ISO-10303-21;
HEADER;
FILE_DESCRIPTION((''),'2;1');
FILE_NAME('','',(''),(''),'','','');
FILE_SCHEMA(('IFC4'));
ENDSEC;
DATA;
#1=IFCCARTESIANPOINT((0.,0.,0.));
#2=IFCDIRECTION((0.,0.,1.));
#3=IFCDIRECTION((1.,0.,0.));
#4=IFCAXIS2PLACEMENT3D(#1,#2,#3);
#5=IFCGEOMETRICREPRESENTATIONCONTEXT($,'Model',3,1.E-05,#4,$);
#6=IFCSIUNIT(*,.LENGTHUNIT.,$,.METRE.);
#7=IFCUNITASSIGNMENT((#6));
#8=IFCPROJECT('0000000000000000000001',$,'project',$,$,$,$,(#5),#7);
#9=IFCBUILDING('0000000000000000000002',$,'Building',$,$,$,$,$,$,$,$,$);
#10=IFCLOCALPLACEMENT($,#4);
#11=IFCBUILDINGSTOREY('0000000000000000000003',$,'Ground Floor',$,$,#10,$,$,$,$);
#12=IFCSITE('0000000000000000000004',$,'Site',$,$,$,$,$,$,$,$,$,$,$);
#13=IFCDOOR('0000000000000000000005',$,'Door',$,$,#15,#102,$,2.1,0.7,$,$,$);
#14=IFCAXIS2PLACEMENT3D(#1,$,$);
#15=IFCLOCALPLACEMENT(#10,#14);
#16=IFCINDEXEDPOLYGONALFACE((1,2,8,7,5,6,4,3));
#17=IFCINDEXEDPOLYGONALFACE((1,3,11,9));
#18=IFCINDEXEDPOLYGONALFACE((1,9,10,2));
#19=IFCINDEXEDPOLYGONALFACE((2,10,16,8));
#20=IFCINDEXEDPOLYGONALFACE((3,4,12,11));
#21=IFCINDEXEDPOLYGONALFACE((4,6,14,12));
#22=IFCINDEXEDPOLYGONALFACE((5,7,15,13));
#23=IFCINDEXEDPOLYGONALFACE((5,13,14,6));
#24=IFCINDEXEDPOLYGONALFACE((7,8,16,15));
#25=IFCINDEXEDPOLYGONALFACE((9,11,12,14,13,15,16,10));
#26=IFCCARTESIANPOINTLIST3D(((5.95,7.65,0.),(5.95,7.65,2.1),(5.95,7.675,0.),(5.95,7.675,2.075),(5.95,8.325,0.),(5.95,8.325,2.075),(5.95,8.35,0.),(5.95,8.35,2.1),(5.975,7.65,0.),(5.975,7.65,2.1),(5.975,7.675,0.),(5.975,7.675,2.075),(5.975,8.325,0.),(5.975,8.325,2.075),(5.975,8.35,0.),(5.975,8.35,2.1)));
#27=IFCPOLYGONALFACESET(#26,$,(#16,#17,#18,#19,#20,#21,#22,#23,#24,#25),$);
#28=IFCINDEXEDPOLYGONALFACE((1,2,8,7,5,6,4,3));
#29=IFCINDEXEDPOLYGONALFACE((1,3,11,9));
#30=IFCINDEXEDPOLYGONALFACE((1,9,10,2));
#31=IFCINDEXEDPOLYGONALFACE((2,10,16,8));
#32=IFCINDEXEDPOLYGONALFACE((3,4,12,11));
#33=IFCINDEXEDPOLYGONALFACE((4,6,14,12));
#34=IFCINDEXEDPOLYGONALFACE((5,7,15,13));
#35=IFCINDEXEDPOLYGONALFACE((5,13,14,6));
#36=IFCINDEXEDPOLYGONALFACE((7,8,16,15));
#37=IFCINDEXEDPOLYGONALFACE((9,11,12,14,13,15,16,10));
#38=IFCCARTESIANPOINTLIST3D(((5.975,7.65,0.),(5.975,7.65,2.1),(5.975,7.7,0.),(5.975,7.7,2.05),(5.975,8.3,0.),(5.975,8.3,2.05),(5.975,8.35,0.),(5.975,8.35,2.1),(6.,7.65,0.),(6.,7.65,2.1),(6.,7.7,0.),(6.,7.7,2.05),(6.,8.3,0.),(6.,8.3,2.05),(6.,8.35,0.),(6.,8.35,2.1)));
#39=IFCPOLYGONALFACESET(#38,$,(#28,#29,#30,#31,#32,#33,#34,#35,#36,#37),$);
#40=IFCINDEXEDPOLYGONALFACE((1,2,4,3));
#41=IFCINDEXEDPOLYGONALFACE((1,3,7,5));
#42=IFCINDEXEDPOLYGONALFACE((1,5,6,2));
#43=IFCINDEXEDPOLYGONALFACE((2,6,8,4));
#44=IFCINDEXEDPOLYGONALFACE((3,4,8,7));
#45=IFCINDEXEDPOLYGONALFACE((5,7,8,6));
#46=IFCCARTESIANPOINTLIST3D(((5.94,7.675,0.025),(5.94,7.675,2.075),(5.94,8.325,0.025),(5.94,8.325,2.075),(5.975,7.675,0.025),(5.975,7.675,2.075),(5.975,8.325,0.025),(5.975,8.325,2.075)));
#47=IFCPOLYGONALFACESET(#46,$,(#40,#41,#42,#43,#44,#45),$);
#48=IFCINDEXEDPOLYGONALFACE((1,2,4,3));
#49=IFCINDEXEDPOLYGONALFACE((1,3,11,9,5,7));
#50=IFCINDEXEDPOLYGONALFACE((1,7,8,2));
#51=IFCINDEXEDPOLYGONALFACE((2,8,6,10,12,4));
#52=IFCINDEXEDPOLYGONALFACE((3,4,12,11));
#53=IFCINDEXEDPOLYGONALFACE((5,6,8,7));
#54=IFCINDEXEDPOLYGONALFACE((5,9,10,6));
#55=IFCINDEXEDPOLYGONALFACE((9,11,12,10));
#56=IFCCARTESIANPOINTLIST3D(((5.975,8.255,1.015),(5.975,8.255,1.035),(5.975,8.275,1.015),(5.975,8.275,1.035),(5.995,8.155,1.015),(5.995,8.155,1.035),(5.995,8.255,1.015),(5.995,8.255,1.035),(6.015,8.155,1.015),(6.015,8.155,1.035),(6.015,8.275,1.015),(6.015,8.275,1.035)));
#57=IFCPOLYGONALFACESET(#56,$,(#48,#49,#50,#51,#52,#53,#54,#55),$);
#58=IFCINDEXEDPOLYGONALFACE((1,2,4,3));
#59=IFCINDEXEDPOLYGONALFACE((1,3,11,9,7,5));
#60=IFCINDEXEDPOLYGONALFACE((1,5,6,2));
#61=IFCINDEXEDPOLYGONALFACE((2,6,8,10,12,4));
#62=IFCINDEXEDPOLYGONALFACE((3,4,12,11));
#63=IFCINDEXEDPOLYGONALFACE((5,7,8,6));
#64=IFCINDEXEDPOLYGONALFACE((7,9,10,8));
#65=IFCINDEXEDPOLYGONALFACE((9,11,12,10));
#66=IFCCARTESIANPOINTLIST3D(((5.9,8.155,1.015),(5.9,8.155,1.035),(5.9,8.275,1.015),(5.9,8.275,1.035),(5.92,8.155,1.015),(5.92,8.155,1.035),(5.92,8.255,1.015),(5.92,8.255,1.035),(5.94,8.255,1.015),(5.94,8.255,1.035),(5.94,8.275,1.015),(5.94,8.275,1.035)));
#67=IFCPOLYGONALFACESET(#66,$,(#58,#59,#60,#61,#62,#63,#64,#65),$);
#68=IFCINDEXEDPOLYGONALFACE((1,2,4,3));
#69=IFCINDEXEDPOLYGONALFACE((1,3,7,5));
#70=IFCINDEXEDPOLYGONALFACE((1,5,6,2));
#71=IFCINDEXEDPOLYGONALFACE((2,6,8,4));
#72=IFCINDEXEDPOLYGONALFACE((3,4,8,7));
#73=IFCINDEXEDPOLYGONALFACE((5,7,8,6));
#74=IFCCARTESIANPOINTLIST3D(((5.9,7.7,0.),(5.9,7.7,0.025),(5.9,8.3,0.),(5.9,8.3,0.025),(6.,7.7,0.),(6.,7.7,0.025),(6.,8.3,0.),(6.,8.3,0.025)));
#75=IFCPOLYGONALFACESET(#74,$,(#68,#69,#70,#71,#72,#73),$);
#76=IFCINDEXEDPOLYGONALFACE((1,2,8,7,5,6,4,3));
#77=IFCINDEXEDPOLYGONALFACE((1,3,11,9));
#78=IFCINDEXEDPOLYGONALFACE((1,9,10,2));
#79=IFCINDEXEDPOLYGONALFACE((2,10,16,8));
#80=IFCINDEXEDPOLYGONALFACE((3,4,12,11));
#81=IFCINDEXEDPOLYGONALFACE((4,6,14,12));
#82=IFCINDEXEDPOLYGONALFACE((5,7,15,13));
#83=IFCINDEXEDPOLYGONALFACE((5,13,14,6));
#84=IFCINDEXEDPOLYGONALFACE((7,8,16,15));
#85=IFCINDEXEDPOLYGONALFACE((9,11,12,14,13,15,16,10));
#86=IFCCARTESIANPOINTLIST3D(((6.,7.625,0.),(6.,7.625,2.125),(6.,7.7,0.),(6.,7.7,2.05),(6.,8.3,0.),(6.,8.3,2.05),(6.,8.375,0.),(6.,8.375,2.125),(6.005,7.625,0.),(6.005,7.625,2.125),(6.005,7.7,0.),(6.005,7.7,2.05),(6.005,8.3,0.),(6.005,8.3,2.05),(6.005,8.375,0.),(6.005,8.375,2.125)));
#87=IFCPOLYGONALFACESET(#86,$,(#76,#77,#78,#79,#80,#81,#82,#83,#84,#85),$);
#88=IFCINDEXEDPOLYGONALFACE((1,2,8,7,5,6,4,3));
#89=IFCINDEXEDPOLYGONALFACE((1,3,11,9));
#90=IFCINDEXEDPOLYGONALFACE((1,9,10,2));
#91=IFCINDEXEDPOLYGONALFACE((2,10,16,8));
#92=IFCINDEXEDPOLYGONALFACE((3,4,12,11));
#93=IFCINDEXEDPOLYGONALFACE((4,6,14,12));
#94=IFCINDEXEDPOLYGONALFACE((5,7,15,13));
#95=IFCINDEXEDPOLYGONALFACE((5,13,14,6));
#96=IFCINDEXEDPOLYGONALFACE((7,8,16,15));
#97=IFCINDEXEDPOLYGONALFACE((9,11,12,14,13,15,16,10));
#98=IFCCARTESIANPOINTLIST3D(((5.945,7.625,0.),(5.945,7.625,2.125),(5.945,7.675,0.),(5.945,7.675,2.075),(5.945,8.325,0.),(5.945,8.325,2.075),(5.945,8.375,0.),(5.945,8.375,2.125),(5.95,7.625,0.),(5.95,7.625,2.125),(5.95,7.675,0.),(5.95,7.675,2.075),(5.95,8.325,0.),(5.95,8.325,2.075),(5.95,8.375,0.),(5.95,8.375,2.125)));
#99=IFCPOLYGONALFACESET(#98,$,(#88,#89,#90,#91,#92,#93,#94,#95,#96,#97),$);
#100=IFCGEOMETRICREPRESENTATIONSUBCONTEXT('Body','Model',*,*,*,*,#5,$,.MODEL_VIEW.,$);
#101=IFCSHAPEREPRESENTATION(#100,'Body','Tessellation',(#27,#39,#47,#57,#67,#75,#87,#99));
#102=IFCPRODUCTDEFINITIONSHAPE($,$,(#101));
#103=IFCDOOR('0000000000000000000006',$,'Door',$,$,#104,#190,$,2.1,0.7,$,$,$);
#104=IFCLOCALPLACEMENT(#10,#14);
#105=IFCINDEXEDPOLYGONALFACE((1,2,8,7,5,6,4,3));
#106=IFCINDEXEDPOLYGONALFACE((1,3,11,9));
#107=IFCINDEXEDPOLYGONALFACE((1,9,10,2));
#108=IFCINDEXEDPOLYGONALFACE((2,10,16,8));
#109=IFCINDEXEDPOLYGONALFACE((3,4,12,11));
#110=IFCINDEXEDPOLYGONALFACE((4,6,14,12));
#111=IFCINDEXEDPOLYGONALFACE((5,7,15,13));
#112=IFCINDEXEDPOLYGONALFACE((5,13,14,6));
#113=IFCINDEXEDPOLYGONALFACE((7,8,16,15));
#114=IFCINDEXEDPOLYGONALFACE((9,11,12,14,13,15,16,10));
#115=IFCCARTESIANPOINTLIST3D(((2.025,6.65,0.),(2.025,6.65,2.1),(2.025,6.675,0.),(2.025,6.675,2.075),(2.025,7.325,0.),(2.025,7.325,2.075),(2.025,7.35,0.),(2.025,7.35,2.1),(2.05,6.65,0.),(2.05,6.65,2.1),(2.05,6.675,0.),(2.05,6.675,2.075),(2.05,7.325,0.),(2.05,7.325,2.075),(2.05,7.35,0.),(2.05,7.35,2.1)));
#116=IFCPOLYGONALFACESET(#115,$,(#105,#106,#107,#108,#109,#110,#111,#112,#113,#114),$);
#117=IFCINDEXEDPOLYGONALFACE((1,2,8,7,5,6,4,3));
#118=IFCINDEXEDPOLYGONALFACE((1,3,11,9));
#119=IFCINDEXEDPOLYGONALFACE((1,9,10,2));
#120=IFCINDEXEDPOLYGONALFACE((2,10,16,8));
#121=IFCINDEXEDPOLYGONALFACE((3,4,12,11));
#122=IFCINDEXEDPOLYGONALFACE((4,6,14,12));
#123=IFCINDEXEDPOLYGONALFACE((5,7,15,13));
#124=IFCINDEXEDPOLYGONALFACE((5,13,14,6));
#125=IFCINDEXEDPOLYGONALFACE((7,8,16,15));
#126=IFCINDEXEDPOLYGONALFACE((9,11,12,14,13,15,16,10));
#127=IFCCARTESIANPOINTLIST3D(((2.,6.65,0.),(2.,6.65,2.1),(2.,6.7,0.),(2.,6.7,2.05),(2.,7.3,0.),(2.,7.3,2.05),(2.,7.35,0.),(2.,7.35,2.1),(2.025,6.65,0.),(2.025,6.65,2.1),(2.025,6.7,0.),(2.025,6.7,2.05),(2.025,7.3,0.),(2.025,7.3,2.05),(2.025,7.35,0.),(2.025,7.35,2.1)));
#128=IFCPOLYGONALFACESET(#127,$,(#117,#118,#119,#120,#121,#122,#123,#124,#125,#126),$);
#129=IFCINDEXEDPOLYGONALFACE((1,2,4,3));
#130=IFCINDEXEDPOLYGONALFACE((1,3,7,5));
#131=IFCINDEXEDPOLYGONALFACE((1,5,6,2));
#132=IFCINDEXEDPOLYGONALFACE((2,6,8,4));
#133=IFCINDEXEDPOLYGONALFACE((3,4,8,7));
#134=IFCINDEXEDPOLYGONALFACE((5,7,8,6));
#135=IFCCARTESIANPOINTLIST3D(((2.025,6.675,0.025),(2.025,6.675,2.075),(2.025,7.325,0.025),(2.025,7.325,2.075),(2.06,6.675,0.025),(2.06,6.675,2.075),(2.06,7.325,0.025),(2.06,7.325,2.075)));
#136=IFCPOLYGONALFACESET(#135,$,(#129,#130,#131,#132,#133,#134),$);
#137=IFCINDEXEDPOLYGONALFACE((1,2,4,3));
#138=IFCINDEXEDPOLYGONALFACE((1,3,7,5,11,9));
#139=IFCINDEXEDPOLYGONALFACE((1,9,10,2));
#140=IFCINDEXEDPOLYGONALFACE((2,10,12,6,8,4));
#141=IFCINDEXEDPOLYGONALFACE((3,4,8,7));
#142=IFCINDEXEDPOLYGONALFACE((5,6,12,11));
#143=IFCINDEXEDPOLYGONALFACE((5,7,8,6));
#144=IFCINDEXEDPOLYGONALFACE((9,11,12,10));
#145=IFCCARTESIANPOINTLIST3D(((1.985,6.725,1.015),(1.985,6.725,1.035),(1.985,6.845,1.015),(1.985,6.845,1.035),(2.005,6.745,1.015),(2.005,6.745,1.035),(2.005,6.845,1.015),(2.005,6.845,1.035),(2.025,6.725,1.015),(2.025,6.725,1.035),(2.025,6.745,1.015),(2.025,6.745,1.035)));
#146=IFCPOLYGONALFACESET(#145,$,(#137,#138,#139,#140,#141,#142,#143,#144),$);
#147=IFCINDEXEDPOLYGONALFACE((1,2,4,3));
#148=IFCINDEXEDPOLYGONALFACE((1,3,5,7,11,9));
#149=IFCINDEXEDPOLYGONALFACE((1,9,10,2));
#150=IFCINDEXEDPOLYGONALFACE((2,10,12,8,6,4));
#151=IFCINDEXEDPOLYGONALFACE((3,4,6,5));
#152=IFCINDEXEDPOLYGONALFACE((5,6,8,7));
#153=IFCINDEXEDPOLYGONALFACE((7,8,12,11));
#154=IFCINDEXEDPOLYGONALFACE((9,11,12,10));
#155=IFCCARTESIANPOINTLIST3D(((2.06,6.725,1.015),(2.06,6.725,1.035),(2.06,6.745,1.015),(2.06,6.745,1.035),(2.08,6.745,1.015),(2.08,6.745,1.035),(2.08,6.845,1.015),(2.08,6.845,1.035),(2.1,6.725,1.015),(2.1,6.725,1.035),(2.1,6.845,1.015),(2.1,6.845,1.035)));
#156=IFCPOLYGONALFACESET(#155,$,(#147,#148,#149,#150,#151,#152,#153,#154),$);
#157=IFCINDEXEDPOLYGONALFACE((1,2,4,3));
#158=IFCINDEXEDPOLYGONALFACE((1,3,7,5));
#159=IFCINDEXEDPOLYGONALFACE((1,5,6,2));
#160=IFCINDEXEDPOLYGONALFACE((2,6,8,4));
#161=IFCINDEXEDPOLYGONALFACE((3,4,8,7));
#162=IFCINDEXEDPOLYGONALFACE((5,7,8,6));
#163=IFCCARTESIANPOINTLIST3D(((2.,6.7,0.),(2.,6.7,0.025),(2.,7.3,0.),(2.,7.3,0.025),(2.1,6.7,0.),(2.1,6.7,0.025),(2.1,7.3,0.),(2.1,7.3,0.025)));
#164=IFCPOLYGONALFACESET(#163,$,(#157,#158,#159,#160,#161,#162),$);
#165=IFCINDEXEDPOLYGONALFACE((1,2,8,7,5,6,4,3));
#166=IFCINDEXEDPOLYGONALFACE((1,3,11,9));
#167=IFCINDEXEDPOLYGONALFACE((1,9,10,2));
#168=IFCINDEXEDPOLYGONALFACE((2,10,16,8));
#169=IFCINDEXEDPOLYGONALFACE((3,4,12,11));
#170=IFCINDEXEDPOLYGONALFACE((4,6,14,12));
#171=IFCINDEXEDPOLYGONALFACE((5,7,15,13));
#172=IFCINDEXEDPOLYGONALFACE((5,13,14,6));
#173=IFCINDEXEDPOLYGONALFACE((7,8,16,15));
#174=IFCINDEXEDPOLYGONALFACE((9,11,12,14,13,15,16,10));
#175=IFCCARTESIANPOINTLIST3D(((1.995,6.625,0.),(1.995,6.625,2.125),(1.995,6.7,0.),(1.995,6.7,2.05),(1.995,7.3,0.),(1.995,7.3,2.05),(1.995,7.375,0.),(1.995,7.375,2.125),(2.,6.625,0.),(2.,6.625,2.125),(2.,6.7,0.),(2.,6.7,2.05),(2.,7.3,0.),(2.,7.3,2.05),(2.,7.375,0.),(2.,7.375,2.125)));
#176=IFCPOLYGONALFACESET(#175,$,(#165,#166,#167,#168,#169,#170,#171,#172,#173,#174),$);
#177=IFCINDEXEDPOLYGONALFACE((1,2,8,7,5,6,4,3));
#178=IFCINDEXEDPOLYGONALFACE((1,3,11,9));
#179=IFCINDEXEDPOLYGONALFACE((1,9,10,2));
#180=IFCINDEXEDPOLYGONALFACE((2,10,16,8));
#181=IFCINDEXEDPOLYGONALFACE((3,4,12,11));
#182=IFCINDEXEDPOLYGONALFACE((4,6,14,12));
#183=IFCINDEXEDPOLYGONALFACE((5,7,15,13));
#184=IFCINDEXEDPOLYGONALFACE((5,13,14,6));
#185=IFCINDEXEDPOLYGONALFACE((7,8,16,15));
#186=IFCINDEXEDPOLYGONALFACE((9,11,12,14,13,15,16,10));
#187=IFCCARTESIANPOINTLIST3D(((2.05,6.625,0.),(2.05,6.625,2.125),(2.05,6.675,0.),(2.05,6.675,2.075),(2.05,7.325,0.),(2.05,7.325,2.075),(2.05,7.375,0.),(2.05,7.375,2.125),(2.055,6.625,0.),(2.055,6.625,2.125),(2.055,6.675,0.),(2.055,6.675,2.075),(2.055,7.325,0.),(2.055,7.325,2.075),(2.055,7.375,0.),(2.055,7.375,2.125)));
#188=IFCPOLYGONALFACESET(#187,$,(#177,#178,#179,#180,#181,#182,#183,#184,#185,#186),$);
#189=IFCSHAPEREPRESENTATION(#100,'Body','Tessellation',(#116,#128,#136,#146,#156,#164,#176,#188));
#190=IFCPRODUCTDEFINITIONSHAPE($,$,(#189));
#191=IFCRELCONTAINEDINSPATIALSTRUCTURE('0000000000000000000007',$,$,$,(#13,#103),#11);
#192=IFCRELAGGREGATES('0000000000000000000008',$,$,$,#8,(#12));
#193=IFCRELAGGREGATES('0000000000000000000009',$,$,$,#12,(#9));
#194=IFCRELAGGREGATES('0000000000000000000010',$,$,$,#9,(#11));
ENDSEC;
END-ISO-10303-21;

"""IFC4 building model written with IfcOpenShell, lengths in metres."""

from ifc_helpers import new_model, si_unit, frame, origin_with_axes, place, context, subcontext, project, spatial, line, indexed_curve, outline, extrude, element, save


model = new_model("IFC4")

# Units and contexts
model_context = context("Model", 3, precision=1e-05, world=origin_with_axes())
body_context = subcontext(model_context, "Body", "Model", "MODEL_VIEW")
ifc_project = project(units=[si_unit("LENGTHUNIT", "METRE")], contexts=[model_context])

# Site, building, storey
site = spatial("IfcSite", under=ifc_project, Name="Site")
building = spatial("IfcBuilding", under=site, Name="Building")
storey_placement = place(None, origin_with_axes())
storey = spatial("IfcBuildingStorey", under=building, at=storey_placement, Name="Ground Floor")

# Doors
door_1_placement = place(storey_placement, frame((6.0, 7.65, 0.0), z_axis=(0.0, 0.0, 1.0), x_axis=(0.0, 1.0, 0.0)))
element("IfcDoor", 1, at=door_1_placement, inside=storey, Name="Door", OverallHeight=2.1, OverallWidth=0.7, context=body_context, shape_type="SweptSolid", body=[
    extrude(outline(indexed_curve([(0.0, 0.0), (0.0, 2.1), (0.7, 2.1), (0.7, 0.0), (0.675, 0.0), (0.675, 2.075), (0.025, 2.075), (0.025, 0.0)], segments=[line(1, 2, 3, 4, 5, 6, 7, 8, 1)])), frame((0.0, 0.025, 0.0), z_axis=(0.0, -1.0, 0.0), x_axis=(1.0, 0.0, 0.0)), (0.0, 0.0, -1.0), 0.025),
    extrude(outline(indexed_curve([(0.0, 0.0), (0.0, 2.1), (0.7, 2.1), (0.7, 0.0), (0.65, 0.0), (0.65, 2.05), (0.05, 2.05), (0.05, 0.0)], segments=[line(1, 2, 3, 4, 5, 6, 7, 8, 1)])), frame((0.0, 0.0, 0.0), z_axis=(0.0, -1.0, 0.0), x_axis=(1.0, 0.0, 0.0)), (0.0, 0.0, -1.0), 0.025),
    extrude(outline(indexed_curve([(0.0, 0.0), (0.65, 0.0), (0.65, 0.035), (0.0, 0.035)], segments=[line(1, 2, 3, 4, 1)])), frame((0.025, 0.025, 0.025), z_axis=(0.0, 0.0, 1.0), x_axis=(1.0, 0.0, 0.0)), (0.0, 0.0, 1.0), 2.05),
    extrude(outline(indexed_curve([(0.0, 0.0), (0.0, -0.04), (-0.12, -0.04), (-0.12, -0.02), (-0.02, -0.02), (-0.02, 0.0)], segments=[line(1, 2, 3, 4, 5, 6, 1)])), frame((0.625, 0.025, 1.015), z_axis=(0.0, 0.0, 1.0), x_axis=(1.0, 0.0, 0.0)), (0.0, 0.0, 1.0), 0.02),
    extrude(outline(indexed_curve([(0.0, 0.0), (0.0, 0.04), (-0.12, 0.04), (-0.12, 0.02), (-0.02, 0.02), (-0.02, 0.0)], segments=[line(1, 2, 3, 4, 5, 6, 1)])), frame((0.625, 0.06, 1.015), z_axis=(0.0, 0.0, 1.0), x_axis=(1.0, 0.0, 0.0)), (0.0, 0.0, 1.0), 0.02),
    extrude(outline(indexed_curve([(0.0, 0.0), (0.6, 0.0), (0.6, 0.1), (0.0, 0.1)], segments=[line(1, 2, 3, 4, 1)])), frame((0.05, 0.0, 0.0), z_axis=(0.0, 0.0, 1.0), x_axis=(1.0, 0.0, 0.0)), (0.0, 0.0, 1.0), 0.025),
    extrude(outline(indexed_curve([(0.0, 0.0), (0.0, 2.125), (0.75, 2.125), (0.75, 0.0), (0.675, 0.0), (0.675, 2.05), (0.075, 2.05), (0.075, 0.0)], segments=[line(1, 2, 3, 4, 5, 6, 7, 8, 1)])), frame((-0.025, -0.005, 0.0), z_axis=(0.0, -1.0, 0.0), x_axis=(1.0, 0.0, 0.0)), (0.0, 0.0, -1.0), 0.005),
    extrude(outline(indexed_curve([(0.0, 0.0), (0.0, 2.125), (0.75, 2.125), (0.75, 0.0), (0.7, 0.0), (0.7, 2.075), (0.05, 2.075), (0.05, 0.0)], segments=[line(1, 2, 3, 4, 5, 6, 7, 8, 1)])), frame((-0.025, 0.05, 0.0), z_axis=(0.0, -1.0, 0.0), x_axis=(1.0, 0.0, 0.0)), (0.0, 0.0, -1.0), 0.005),
])
door_2_placement = place(storey_placement, frame((2.0, 7.35, 0.0), z_axis=(0.0, 0.0, 1.0), x_axis=(0.0, -1.0, 0.0)))
element("IfcDoor", 2, at=door_2_placement, inside=storey, Name="Door", OverallHeight=2.1, OverallWidth=0.7, context=body_context, shape_type="SweptSolid", body=[
    extrude(outline(indexed_curve([(0.0, 0.0), (0.0, 2.1), (0.7, 2.1), (0.7, 0.0), (0.675, 0.0), (0.675, 2.075), (0.025, 2.075), (0.025, 0.0)], segments=[line(1, 2, 3, 4, 5, 6, 7, 8, 1)])), frame((0.0, 0.025, 0.0), z_axis=(0.0, -1.0, 0.0), x_axis=(1.0, 0.0, 0.0)), (0.0, 0.0, -1.0), 0.025),
    extrude(outline(indexed_curve([(0.0, 0.0), (0.0, 2.1), (0.7, 2.1), (0.7, 0.0), (0.65, 0.0), (0.65, 2.05), (0.05, 2.05), (0.05, 0.0)], segments=[line(1, 2, 3, 4, 5, 6, 7, 8, 1)])), frame((0.0, 0.0, 0.0), z_axis=(0.0, -1.0, 0.0), x_axis=(1.0, 0.0, 0.0)), (0.0, 0.0, -1.0), 0.025),
    extrude(outline(indexed_curve([(0.0, 0.0), (0.65, 0.0), (0.65, 0.035), (0.0, 0.035)], segments=[line(1, 2, 3, 4, 1)])), frame((0.025, 0.025, 0.025), z_axis=(0.0, 0.0, 1.0), x_axis=(1.0, 0.0, 0.0)), (0.0, 0.0, 1.0), 2.05),
    extrude(outline(indexed_curve([(0.0, 0.0), (0.0, -0.04), (-0.12, -0.04), (-0.12, -0.02), (-0.02, -0.02), (-0.02, 0.0)], segments=[line(1, 2, 3, 4, 5, 6, 1)])), frame((0.625, 0.025, 1.015), z_axis=(0.0, 0.0, 1.0), x_axis=(1.0, 0.0, 0.0)), (0.0, 0.0, 1.0), 0.02),
    extrude(outline(indexed_curve([(0.0, 0.0), (0.0, 0.04), (-0.12, 0.04), (-0.12, 0.02), (-0.02, 0.02), (-0.02, 0.0)], segments=[line(1, 2, 3, 4, 5, 6, 1)])), frame((0.625, 0.06, 1.015), z_axis=(0.0, 0.0, 1.0), x_axis=(1.0, 0.0, 0.0)), (0.0, 0.0, 1.0), 0.02),
    extrude(outline(indexed_curve([(0.0, 0.0), (0.6, 0.0), (0.6, 0.1), (0.0, 0.1)], segments=[line(1, 2, 3, 4, 1)])), frame((0.05, 0.0, 0.0), z_axis=(0.0, 0.0, 1.0), x_axis=(1.0, 0.0, 0.0)), (0.0, 0.0, 1.0), 0.025),
    extrude(outline(indexed_curve([(0.0, 0.0), (0.0, 2.125), (0.75, 2.125), (0.75, 0.0), (0.675, 0.0), (0.675, 2.05), (0.075, 2.05), (0.075, 0.0)], segments=[line(1, 2, 3, 4, 5, 6, 7, 8, 1)])), frame((-0.025, -0.005, 0.0), z_axis=(0.0, -1.0, 0.0), x_axis=(1.0, 0.0, 0.0)), (0.0, 0.0, -1.0), 0.005),
    extrude(outline(indexed_curve([(0.0, 0.0), (0.0, 2.125), (0.75, 2.125), (0.75, 0.0), (0.7, 0.0), (0.7, 2.075), (0.05, 2.075), (0.05, 0.0)], segments=[line(1, 2, 3, 4, 5, 6, 7, 8, 1)])), frame((-0.025, 0.05, 0.0), z_axis=(0.0, -1.0, 0.0), x_axis=(1.0, 0.0, 0.0)), (0.0, 0.0, -1.0), 0.005),
])

save(model, "model.ifc")
